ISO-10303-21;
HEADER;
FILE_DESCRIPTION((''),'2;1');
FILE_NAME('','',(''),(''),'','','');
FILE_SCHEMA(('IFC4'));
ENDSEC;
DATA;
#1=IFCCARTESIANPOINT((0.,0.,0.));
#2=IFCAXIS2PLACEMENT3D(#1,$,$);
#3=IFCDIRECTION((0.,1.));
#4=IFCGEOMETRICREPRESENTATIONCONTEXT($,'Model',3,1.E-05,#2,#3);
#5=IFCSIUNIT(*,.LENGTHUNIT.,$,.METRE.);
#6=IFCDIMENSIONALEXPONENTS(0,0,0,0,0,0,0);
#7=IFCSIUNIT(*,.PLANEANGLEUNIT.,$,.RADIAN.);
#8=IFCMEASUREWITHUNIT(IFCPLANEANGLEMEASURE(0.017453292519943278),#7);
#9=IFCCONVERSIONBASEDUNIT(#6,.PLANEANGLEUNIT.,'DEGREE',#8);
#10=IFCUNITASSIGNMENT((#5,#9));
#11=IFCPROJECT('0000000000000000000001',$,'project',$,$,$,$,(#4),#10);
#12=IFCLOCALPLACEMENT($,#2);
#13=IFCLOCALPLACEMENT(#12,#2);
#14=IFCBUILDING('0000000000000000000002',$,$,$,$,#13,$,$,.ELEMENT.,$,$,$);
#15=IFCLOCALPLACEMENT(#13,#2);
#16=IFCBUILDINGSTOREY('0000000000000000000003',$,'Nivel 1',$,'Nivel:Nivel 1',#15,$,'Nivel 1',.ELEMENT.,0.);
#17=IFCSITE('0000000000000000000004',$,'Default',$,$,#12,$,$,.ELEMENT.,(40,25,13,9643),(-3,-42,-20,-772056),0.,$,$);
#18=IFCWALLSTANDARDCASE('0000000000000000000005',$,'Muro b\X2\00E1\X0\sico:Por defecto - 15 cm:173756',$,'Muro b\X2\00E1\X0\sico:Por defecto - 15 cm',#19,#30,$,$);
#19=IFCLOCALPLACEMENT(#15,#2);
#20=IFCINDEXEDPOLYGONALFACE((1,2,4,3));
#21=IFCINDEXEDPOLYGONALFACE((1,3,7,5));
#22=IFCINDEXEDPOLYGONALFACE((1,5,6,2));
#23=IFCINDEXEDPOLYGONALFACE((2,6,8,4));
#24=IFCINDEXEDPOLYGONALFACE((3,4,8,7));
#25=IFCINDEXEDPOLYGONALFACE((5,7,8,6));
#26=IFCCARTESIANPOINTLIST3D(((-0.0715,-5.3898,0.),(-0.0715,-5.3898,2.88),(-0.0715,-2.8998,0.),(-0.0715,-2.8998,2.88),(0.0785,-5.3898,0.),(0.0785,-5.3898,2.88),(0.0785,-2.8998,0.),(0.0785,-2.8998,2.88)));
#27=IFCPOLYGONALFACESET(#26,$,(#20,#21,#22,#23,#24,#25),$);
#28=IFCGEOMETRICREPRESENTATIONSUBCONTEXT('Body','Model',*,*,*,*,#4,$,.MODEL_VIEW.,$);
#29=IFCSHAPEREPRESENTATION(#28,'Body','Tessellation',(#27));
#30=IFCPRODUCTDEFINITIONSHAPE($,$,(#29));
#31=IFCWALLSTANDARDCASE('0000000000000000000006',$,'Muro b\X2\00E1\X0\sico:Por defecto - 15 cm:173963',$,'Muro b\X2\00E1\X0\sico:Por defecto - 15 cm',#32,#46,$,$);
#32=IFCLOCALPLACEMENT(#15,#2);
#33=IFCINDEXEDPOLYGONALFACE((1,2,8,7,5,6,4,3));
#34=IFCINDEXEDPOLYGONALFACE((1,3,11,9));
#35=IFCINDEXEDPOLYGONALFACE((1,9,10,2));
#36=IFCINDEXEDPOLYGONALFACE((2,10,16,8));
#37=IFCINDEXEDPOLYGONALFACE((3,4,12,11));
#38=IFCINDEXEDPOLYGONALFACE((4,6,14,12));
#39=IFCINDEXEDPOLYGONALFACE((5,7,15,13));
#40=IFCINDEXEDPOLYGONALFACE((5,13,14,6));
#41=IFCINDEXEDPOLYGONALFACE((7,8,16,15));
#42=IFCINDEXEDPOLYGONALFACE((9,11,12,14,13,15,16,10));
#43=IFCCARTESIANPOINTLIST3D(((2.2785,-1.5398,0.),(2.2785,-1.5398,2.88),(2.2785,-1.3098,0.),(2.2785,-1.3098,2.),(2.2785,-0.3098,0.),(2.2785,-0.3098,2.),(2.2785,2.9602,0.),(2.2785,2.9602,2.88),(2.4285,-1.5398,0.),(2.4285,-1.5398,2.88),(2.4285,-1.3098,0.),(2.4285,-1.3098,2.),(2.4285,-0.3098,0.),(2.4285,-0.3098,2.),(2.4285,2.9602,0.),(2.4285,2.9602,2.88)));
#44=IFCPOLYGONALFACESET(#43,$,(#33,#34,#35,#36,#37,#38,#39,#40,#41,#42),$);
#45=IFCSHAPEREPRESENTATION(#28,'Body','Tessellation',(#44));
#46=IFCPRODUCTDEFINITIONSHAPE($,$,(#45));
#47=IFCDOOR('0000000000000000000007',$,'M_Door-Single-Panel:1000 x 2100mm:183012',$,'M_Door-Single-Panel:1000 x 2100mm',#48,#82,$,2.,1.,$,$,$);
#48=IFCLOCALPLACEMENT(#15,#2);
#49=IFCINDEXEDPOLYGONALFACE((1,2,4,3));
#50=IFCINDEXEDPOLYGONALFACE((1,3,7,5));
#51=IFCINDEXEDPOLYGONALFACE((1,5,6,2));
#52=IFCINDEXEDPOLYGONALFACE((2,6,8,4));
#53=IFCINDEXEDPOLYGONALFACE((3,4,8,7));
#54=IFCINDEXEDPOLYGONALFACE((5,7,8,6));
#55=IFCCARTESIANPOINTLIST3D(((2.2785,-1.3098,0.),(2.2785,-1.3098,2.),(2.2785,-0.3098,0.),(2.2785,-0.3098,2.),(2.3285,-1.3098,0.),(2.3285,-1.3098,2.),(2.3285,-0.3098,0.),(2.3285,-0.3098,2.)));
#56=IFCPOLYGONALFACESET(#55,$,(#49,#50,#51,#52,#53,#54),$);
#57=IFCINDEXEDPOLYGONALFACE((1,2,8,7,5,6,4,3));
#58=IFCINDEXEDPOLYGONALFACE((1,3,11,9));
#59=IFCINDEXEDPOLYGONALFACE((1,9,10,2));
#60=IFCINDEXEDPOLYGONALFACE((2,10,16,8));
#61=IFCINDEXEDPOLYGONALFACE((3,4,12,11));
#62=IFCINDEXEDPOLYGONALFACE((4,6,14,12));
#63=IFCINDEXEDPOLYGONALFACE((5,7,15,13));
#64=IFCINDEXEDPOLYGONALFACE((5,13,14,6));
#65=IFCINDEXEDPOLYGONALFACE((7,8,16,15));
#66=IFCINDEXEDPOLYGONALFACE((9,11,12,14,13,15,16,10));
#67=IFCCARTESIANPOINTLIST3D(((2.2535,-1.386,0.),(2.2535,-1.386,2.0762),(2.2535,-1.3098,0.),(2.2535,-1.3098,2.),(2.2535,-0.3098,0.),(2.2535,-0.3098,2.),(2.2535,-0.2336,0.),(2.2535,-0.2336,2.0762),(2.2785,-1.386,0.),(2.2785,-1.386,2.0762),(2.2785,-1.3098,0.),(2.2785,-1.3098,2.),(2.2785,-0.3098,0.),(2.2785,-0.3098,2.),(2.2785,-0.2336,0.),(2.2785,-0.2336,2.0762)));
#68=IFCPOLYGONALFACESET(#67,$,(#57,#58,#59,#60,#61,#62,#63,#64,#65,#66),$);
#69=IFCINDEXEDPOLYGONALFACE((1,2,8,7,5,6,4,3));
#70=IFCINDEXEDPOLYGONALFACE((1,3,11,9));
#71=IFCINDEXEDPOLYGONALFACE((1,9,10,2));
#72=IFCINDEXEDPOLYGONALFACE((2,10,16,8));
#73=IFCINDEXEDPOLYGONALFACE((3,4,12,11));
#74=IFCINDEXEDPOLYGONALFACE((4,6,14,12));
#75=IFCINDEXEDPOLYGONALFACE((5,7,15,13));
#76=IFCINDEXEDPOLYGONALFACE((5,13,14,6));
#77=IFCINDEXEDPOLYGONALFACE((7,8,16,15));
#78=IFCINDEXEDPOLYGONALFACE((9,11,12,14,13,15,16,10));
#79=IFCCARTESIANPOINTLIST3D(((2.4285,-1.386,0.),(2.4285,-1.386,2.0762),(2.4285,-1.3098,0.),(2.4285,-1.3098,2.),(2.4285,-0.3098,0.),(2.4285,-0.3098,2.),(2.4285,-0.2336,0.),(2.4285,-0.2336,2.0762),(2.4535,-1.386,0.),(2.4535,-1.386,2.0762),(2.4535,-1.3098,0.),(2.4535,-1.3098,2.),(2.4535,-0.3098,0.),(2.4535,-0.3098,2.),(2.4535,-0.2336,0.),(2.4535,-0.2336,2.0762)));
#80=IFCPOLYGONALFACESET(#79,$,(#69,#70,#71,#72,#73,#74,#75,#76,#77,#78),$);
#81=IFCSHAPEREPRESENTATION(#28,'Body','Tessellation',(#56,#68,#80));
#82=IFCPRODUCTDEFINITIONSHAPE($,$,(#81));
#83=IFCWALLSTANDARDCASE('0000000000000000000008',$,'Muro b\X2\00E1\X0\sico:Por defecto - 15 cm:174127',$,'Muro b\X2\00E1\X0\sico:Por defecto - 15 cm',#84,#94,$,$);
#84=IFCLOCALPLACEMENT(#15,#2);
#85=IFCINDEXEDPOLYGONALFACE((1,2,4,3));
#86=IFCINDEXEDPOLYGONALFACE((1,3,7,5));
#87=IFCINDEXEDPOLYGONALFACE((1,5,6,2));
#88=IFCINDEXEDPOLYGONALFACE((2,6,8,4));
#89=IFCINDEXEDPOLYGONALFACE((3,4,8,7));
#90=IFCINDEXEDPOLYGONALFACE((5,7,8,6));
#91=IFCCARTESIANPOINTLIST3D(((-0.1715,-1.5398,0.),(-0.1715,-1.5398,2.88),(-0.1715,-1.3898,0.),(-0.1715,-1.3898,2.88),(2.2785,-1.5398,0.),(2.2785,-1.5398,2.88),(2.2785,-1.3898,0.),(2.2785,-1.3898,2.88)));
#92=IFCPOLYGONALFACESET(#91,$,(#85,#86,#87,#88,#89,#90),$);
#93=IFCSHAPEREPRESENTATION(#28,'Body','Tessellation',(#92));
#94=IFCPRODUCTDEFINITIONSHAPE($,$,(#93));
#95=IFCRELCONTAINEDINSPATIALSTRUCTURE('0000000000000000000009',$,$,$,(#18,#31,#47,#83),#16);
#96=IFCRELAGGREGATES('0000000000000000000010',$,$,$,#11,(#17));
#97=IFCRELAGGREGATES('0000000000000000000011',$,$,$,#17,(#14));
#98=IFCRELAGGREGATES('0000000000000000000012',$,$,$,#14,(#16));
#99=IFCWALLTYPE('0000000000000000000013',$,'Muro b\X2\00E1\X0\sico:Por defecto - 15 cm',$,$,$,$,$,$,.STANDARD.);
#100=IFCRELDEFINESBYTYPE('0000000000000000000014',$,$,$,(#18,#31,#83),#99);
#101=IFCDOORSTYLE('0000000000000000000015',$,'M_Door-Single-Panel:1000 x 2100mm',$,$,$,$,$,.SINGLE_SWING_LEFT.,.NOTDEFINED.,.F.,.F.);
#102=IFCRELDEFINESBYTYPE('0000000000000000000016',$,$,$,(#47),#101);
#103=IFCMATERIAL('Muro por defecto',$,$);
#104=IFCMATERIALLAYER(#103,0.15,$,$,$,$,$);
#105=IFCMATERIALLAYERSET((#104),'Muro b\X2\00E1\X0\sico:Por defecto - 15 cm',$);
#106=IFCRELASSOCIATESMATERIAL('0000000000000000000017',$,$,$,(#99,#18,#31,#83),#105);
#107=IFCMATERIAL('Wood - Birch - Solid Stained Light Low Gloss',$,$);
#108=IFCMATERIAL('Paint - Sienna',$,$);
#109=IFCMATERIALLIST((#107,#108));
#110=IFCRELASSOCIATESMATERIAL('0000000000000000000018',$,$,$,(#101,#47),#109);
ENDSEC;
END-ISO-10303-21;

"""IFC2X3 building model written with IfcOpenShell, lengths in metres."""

from ifc_helpers import new_model, entity, si_unit, converted_unit, direction, frame, frame_2d, origin, origin_2d_with_axis, place, context, subcontext, project, spatial, polyline, rectangle, outline, extrude, clip, bounded_halfspace, source, transform, mapped, material, material_list, layer, layer_set, layer_usage, type_object, type_shapes, element, fill, save


model = new_model("IFC2X3")

# Units and contexts
model_context = context("Model", 3, precision=1e-05, world=origin(), true_north=direction((0.0, 1.0)))
body_context = subcontext(model_context, "Body", "Model", "MODEL_VIEW")
ifc_project = project(units=[si_unit("LENGTHUNIT", "METRE"), converted_unit("PLANEANGLEUNIT", "DEGREE", entity("IfcPlaneAngleMeasure", 0.017453292519943278), si_unit("PLANEANGLEUNIT", "RADIAN"), dimensions=[0, 0, 0, 0, 0, 0, 0])], contexts=[model_context])

# Site, building, storey
site_placement = place(None, origin())
site = spatial("IfcSite", under=ifc_project, at=site_placement, Name="Default", CompositionType="ELEMENT", RefLatitude=(40, 25, 13, 9643), RefLongitude=(-3, -42, -20, -772056), RefElevation=0.0)
building_placement = place(site_placement, origin())
building = spatial("IfcBuilding", under=site, at=building_placement, CompositionType="ELEMENT")
storey_placement = place(building_placement, origin())
storey = spatial("IfcBuildingStorey", under=building, at=storey_placement, Name="Nivel 1", ObjectType="Nivel:Nivel 1", LongName="Nivel 1", CompositionType="ELEMENT", Elevation=0.0)

# Shared definitions
ifc_material_1 = material(Name="Muro por defecto")
ifc_layer = layer(ifc_material_1, 0.15)
ifc_layer_set = layer_set([ifc_layer], Name="Muro básico:Por defecto - 15 cm")
wall_type = type_object("IfcWallType", Name="Muro básico:Por defecto - 15 cm", PredefinedType="STANDARD", material=ifc_layer_set)

# Shared definitions
ifc_material_2 = material(Name="Wood - Birch - Solid Stained Light Low Gloss")
ifc_material_3 = material(Name="Paint - Sienna")
ifc_material_list_1 = material_list([ifc_material_2, ifc_material_3])
door_style_1 = type_object("IfcDoorStyle", Name="M_Door-Single-Panel:1000 x 2100mm", ConstructionType="NOTDEFINED", OperationType="SINGLE_SWING_LEFT", ParameterTakesPrecedence=False, Sizeable=False, material=ifc_material_list_1)
shared_shape_1 = source(origin(), body_context, "Body", "SweptSolid", [
    extrude(rectangle(XDim=1.0, YDim=0.05, at=origin_2d_with_axis()), frame((0.5, 0.125, 0.0)), (0.0, 0.0, 1.0), 2.0),
    extrude(outline(polyline([(-0.5762, -1.0571), (0.5762, -1.0571), (0.5762, 1.0191), (0.5, 1.0191), (0.5, -0.981), (-0.5, -0.981), (-0.5, 1.0191), (-0.5762, 1.0191), (-0.5762, -1.0571)])), frame((0.5, 0.175, 1.0191), z_axis=(0.0, -1.0, 0.0), x_axis=(-1.0, 0.0, 0.0)), (0.0, 0.0, 1.0), 0.025),
    extrude(outline(polyline([(-1.0571, -0.5762), (1.019, -0.5762), (1.019, -0.5), (-0.9809, -0.5), (-0.9809, 0.5), (1.019, 0.5), (1.019, 0.5762), (-1.0571, 0.5762), (-1.0571, -0.5762)])), frame((0.5, 0.0, 1.019), z_axis=(0.0, -1.0, 0.0), x_axis=(0.0, 0.0, -1.0)), (0.0, 0.0, 1.0), 0.025),
])
type_shapes(door_style_1, [shared_shape_1])

# Wall
ifc_layer_usage_1 = layer_usage(ifc_layer_set, "AXIS2", "NEGATIVE", 0.075)
wall_1_placement = place(storey_placement, frame((0.0035, -5.3898, 0.0), z_axis=(0.0, 0.0, 1.0), x_axis=(0.0, 1.0, 0.0)))
element("IfcWallStandardCase", 1, at=wall_1_placement, inside=storey, type_object=wall_type, material=ifc_layer_usage_1, Name="Muro básico:Por defecto - 15 cm:173756", ObjectType="Muro básico:Por defecto - 15 cm", context=body_context, shape_type="Clipping", body=[
    clip(extrude(rectangle(XDim=2.49, YDim=0.15, at=frame_2d((1.245, 0.0), x_axis=(-1.0, 0.0))), origin(), (0.0, 0.0, 1.0), 2.88), bounded_halfspace(frame((0.0, -0.075, 2.88), z_axis=(0.0, 0.0, -1.0), x_axis=(0.0, -1.0, 0.0)), True, frame((0.0, -0.075, 2.88)), polyline([(0.0, 0.0), (2.49, 0.0), (2.49, 0.15), (0.0, 0.15), (0.0, 0.0)]))),
])

# Wall, opening, door
ifc_layer_usage_2 = layer_usage(ifc_layer_set, "AXIS2", "NEGATIVE", 0.075)
wall_2_placement = place(storey_placement, frame((2.3535, 2.9602, 0.0), z_axis=(0.0, 0.0, 1.0), x_axis=(0.0, -1.0, 0.0)))
wall_2 = element("IfcWallStandardCase", 2, at=wall_2_placement, inside=storey, type_object=wall_type, material=ifc_layer_usage_2, Name="Muro básico:Por defecto - 15 cm:173963", ObjectType="Muro básico:Por defecto - 15 cm", context=body_context, shape_type="Clipping", body=[
    clip(extrude(rectangle(XDim=4.5, YDim=0.15, at=frame_2d((2.25, 0.0), x_axis=(-1.0, 0.0))), origin(), (0.0, 0.0, 1.0), 2.88), bounded_halfspace(frame((0.0, -0.075, 2.88), z_axis=(0.0, 0.0, -1.0), x_axis=(0.0, 1.0, 0.0)), True, frame((0.0, -0.075, 2.88)), polyline([(0.0, 0.0), (4.35, 0.0), (4.5, 0.0), (4.5, 0.15), (0.0, 0.15), (0.0, 0.0)]))),
])
opening_1_placement = place(wall_2_placement, frame((4.27, 0.075, 0.0)))
opening_1 = element("IfcOpeningElement", 3, at=opening_1_placement, cuts=wall_2, ObjectType="Opening", context=body_context, shape_type="SweptSolid", body=[
    extrude(rectangle(XDim=1.0, YDim=2.0, at=frame_2d((1.0, 0.5), x_axis=(0.0, -1.0))), frame((0.0, 0.0, 0.0), z_axis=(0.0, -1.0, 0.0), x_axis=(0.0, 0.0, 1.0)), (0.0, 0.0, 1.0), 0.15),
])
door_1_placement = place(opening_1_placement, frame((0.0, 0.0, 0.0), z_axis=(0.0, 0.0, 1.0), x_axis=(-1.0, 0.0, 0.0)))
door_1 = element("IfcDoor", 4, at=door_1_placement, inside=storey, type_object=door_style_1, material=ifc_material_list_1, Name="M_Door-Single-Panel:1000 x 2100mm:183012", ObjectType="M_Door-Single-Panel:1000 x 2100mm", OverallHeight=2.0, OverallWidth=1.0, context=body_context, shape_type="MappedRepresentation", body=[
    mapped(shared_shape_1, transform((0.0, 0.0, 0.0), scale=1.0)),
])
fill(opening_1, door_1)

# Wall
ifc_layer_usage_3 = layer_usage(ifc_layer_set, "AXIS2", "NEGATIVE", 0.075)
wall_3_placement = place(storey_placement, frame((2.2785, -1.4648, 0.0), z_axis=(0.0, 0.0, 1.0), x_axis=(-1.0, 0.0, 0.0)))
element("IfcWallStandardCase", 5, at=wall_3_placement, inside=storey, type_object=wall_type, material=ifc_layer_usage_3, Name="Muro básico:Por defecto - 15 cm:174127", ObjectType="Muro básico:Por defecto - 15 cm", context=body_context, shape_type="Clipping", body=[
    clip(extrude(rectangle(XDim=2.45, YDim=0.15, at=frame_2d((1.225, 0.0), x_axis=(-1.0, 0.0))), origin(), (0.0, 0.0, 1.0), 2.88), bounded_halfspace(frame((0.0, -0.075, 2.88), z_axis=(0.0, 0.0, -1.0), x_axis=(-1.0, 0.0, 0.0)), True, frame((0.0, -0.075, 2.88)), polyline([(0.0, 0.0), (2.45, 0.0), (2.45, 0.15), (0.0, 0.15), (0.0, 0.0)]))),
])

save(model, "model.ifc")
